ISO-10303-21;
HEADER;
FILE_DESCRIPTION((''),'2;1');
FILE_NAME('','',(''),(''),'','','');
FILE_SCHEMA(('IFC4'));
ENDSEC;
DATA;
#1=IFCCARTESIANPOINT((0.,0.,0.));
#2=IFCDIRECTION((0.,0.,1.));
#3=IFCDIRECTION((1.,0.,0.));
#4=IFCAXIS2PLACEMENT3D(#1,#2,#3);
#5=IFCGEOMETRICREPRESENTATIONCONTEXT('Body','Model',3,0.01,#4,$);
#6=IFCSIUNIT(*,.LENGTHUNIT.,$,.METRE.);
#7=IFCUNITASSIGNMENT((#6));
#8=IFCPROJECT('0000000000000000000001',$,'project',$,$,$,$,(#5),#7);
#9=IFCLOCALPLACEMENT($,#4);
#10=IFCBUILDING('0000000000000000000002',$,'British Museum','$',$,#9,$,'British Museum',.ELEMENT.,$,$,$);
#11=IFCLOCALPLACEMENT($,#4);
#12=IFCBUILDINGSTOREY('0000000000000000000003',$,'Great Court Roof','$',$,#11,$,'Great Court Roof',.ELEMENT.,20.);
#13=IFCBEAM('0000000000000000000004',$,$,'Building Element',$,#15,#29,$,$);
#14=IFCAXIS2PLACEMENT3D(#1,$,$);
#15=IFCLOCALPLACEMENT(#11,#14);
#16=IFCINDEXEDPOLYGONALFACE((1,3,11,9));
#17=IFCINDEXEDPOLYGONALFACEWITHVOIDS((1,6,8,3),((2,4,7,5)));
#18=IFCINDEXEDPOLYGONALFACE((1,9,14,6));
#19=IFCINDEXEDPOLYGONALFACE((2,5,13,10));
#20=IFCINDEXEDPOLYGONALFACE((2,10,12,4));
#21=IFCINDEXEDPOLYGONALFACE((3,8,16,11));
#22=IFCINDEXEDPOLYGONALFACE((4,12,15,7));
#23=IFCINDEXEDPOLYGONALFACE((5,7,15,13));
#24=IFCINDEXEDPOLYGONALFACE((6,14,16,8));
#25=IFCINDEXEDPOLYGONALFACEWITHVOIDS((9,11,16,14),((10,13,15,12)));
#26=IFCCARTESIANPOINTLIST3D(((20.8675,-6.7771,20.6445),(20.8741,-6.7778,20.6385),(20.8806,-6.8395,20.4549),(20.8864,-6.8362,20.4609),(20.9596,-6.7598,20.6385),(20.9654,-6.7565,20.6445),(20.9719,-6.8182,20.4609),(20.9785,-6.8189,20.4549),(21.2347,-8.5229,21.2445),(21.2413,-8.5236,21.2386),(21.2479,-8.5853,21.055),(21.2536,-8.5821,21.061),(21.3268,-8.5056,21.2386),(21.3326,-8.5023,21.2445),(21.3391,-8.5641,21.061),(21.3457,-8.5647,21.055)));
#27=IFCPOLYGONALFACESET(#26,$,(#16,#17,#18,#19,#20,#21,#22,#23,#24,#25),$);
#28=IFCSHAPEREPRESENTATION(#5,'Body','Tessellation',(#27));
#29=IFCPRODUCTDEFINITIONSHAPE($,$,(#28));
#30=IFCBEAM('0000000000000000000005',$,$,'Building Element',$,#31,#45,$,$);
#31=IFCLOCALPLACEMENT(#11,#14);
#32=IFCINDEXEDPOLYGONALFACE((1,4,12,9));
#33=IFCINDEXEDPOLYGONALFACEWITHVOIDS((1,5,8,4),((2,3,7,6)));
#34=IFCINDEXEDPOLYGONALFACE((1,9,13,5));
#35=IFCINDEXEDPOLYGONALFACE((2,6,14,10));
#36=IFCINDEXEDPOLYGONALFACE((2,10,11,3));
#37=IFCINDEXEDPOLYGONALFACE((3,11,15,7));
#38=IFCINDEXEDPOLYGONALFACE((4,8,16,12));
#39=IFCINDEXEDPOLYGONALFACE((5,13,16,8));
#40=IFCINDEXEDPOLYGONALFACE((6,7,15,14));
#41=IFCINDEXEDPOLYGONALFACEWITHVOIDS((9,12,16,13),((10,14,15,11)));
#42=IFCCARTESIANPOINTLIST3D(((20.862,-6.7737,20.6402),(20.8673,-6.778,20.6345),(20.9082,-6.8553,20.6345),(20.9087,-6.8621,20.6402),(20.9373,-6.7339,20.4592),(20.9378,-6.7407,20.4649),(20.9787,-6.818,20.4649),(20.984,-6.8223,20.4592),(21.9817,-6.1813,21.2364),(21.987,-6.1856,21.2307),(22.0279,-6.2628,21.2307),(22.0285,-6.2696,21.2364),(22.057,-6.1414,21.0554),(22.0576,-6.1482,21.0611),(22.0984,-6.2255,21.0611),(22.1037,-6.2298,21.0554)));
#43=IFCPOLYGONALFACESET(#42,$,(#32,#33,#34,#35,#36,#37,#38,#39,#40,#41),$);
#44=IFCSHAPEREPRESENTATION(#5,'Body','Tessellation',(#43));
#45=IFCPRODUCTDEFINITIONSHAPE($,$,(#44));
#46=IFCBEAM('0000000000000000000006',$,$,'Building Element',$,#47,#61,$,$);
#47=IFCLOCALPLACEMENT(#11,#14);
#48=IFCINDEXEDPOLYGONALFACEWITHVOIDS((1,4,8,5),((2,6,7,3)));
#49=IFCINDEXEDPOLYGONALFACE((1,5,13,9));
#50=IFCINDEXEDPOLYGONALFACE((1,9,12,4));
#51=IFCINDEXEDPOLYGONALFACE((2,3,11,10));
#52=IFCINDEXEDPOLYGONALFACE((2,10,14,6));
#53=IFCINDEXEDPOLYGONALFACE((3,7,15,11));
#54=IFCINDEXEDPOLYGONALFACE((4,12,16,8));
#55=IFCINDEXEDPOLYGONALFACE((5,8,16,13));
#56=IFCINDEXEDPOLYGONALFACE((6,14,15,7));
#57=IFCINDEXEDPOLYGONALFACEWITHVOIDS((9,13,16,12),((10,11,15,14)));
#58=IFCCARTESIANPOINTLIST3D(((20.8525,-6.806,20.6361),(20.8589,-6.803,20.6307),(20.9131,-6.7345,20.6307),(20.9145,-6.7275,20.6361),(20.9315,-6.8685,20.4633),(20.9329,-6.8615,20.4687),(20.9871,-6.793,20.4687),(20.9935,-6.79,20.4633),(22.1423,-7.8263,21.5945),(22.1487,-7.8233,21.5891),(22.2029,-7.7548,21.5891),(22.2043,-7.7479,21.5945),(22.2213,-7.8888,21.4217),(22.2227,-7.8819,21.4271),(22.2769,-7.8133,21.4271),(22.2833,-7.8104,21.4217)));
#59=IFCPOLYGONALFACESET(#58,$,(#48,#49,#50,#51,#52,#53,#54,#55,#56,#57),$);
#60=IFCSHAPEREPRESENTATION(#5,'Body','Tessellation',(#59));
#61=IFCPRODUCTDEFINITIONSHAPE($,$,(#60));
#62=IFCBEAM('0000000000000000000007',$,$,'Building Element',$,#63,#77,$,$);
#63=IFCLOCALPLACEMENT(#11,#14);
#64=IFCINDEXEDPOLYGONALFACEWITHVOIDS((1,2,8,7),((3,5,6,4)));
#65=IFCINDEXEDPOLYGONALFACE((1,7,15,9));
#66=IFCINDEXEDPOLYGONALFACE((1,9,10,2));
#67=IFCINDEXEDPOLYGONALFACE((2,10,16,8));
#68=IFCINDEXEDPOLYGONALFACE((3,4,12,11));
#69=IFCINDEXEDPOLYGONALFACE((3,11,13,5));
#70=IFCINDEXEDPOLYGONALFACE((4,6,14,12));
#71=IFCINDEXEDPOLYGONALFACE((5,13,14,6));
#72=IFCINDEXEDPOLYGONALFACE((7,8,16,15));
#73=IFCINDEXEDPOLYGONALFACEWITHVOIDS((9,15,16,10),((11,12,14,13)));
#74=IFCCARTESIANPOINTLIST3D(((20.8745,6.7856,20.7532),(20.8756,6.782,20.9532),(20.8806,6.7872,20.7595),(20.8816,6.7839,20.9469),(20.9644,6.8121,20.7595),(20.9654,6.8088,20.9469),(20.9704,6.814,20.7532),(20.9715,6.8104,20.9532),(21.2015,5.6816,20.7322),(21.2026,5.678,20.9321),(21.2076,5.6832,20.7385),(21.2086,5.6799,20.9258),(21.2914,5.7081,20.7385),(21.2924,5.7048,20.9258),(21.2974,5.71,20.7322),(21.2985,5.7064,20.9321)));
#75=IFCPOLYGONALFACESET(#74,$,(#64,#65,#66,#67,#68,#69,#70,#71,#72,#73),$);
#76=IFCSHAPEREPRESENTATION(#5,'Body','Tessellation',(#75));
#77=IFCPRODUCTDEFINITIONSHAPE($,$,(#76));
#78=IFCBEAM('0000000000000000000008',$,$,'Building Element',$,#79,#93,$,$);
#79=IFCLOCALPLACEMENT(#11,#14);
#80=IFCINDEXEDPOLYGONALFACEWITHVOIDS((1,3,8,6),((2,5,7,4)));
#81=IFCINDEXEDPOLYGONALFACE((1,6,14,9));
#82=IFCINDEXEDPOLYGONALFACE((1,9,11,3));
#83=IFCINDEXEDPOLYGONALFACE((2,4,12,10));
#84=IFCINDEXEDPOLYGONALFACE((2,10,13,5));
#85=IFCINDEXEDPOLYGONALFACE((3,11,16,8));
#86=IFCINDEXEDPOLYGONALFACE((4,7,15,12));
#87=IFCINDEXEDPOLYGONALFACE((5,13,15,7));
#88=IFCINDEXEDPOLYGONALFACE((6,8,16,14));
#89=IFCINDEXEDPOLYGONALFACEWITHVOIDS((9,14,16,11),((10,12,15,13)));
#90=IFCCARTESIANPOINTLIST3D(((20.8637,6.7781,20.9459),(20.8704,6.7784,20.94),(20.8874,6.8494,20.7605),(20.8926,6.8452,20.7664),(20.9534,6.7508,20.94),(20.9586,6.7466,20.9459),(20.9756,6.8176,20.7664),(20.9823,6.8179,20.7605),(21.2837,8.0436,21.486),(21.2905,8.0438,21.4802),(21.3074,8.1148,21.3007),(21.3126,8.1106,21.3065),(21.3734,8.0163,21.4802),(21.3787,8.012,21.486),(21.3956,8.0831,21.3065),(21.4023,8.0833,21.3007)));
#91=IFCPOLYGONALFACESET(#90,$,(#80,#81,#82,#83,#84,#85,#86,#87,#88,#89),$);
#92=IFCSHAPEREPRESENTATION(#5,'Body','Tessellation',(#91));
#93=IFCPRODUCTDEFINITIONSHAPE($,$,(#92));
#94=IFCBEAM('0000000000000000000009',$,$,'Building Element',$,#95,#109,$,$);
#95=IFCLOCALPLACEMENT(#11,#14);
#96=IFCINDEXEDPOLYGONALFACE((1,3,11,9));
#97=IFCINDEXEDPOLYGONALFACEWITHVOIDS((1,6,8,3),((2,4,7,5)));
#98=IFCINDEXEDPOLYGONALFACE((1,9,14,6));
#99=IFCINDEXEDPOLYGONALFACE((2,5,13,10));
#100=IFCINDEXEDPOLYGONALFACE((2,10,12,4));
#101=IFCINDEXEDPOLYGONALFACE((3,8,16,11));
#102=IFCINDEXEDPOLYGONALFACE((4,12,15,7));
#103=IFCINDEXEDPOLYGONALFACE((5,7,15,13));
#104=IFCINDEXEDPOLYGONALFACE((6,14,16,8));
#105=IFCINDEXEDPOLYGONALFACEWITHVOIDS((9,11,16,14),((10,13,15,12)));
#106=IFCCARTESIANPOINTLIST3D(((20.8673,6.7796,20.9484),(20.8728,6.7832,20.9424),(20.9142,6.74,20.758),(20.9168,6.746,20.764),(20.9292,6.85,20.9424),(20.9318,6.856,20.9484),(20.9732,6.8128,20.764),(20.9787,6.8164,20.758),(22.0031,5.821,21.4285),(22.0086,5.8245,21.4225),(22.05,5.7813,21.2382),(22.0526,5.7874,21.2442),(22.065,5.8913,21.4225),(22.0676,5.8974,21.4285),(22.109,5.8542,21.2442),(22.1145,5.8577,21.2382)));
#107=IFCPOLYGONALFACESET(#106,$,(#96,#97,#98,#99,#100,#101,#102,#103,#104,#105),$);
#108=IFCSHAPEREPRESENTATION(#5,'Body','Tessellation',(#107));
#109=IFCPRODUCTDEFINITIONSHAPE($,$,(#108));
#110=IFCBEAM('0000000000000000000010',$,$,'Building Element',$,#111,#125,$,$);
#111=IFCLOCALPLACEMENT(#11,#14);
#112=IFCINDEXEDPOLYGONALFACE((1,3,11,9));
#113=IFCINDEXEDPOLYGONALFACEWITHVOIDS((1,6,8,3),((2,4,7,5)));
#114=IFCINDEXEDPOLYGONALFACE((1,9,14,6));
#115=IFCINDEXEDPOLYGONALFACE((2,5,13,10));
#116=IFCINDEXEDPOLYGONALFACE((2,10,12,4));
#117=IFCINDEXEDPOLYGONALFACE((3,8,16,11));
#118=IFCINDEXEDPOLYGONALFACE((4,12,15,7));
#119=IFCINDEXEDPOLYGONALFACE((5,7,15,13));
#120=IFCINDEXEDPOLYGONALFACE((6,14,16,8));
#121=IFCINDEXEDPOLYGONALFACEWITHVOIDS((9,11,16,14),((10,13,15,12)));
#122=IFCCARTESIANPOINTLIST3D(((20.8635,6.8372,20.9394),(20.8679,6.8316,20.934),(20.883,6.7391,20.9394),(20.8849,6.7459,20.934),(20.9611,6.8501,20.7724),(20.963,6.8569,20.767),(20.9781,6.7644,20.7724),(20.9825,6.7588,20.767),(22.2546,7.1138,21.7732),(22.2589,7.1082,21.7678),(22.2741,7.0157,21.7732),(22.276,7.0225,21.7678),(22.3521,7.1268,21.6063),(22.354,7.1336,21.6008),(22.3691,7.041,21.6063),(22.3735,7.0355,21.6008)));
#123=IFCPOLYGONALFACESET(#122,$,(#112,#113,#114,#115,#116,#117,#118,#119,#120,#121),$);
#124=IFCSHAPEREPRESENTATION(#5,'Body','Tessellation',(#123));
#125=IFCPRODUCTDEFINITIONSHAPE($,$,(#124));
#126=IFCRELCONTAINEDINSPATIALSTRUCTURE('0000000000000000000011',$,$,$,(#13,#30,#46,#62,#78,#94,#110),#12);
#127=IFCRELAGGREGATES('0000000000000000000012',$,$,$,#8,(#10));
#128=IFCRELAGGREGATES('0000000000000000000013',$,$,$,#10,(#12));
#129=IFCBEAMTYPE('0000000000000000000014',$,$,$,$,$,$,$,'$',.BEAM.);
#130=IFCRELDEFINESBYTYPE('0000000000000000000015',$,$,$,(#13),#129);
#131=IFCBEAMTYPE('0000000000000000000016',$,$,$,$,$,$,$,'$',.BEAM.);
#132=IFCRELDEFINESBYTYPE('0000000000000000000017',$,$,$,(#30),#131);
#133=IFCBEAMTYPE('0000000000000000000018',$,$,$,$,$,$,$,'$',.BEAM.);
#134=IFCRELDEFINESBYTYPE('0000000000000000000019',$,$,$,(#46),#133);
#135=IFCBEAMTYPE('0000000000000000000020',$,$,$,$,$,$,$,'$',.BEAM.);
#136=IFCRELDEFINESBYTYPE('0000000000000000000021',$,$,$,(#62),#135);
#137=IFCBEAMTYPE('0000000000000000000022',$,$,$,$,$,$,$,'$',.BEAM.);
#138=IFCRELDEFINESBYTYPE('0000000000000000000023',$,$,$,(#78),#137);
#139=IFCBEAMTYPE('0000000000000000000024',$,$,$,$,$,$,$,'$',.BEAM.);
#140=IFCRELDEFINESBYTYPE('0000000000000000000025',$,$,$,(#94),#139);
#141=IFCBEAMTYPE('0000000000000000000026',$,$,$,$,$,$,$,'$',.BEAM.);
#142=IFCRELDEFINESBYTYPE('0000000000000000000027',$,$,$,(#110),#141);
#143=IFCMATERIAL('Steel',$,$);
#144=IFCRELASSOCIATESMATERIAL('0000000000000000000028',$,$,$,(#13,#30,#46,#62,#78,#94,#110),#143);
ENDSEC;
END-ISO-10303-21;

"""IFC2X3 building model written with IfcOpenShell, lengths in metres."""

from ifc_helpers import new_model, si_unit, frame, origin_with_axes, origin_2d, place, context, project, spatial, hollow_rectangle, extrude, material, type_object, element, save


model = new_model("IFC2X3")

# Units and contexts
model_context = context("Model", 3, precision=0.01, world=origin_with_axes(), identifier="Body")
ifc_project = project(units=[si_unit("LENGTHUNIT", "METRE")], contexts=[model_context])

# Building, storey
building_placement = place(None, origin_with_axes())
building = spatial("IfcBuilding", under=ifc_project, at=building_placement, Name="British Museum", Description="$", LongName="British Museum", CompositionType="ELEMENT")
storey_placement = place(None, origin_with_axes())
storey = spatial("IfcBuildingStorey", under=building, at=storey_placement, Name="Great Court Roof", Description="$", LongName="Great Court Roof", CompositionType="ELEMENT", Elevation=20.0)

# Beams
ifc_material = material(Name="Steel")
beam_type_1 = type_object("IfcBeamType", ElementType="$", PredefinedType="BEAM")
beam_1_placement = place(None, origin_with_axes())
element("IfcBeam", 1, at=beam_1_placement, inside=storey, type_object=beam_type_1, material=ifc_material, Description="Building Element", context=model_context, shape_type="SweptSolid", body=[
    extrude(hollow_rectangle(XDim=0.1, YDim=0.2, WallThickness=0.0063, InnerFilletRadius=-0.0063, OuterFilletRadius=0.0, at=origin_2d()), frame((20.923, -6.798, 20.5497), z_axis=(0.195098, -0.927526, 0.318799), x_axis=(0.978586, 0.205838, 0.0)), (0.0, 0.0, 1.0), 1.8823),
])
beam_type_2 = type_object("IfcBeamType", ElementType="$", PredefinedType="BEAM")
beam_2_placement = place(None, origin_with_axes())
element("IfcBeam", 2, at=beam_2_placement, inside=storey, type_object=beam_type_2, material=ifc_material, Description="Building Element", context=model_context, shape_type="SweptSolid", body=[
    extrude(hollow_rectangle(XDim=0.1, YDim=0.2, WallThickness=0.0063, InnerFilletRadius=-0.0063, OuterFilletRadius=0.0, at=origin_2d()), frame((20.923, -6.798, 20.5497), z_axis=(0.799754, 0.423164, 0.425823), x_axis=(-0.467685, 0.883895, 0.0)), (0.0, 0.0, 1.0), 1.4001),
])
beam_type_3 = type_object("IfcBeamType", ElementType="$", PredefinedType="BEAM")
beam_3_placement = place(None, origin_with_axes())
element("IfcBeam", 3, at=beam_3_placement, inside=storey, type_object=beam_type_3, material=ifc_material, Description="Building Element", context=model_context, shape_type="SweptSolid", body=[
    extrude(hollow_rectangle(XDim=0.1, YDim=0.2, WallThickness=0.0063, InnerFilletRadius=-0.0063, OuterFilletRadius=0.0, at=origin_2d()), frame((20.923, -6.798, 20.5497), z_axis=(0.677604, -0.536043, 0.503499), x_axis=(0.620423, 0.784268, 0.0)), (0.0, 0.0, 1.0), 1.9035),
])
beam_type_4 = type_object("IfcBeamType", ElementType="$", PredefinedType="BEAM")
beam_4_placement = place(None, origin_with_axes())
element("IfcBeam", 4, at=beam_4_placement, inside=storey, type_object=beam_type_4, material=ifc_material, Description="Building Element", context=model_context, shape_type="SweptSolid", body=[
    extrude(hollow_rectangle(XDim=0.1, YDim=0.2, WallThickness=0.0063, InnerFilletRadius=-0.0063, OuterFilletRadius=0.0, at=origin_2d()), frame((20.923, 6.798, 20.8532), z_axis=(0.283952, -0.958664, -0.018263), x_axis=(0.958824, 0.284, 0.0)), (0.0, 0.0, 1.0), 1.1516),
])
beam_type_5 = type_object("IfcBeamType", ElementType="$", PredefinedType="BEAM")
beam_5_placement = place(None, origin_with_axes())
element("IfcBeam", 5, at=beam_5_placement, inside=storey, type_object=beam_type_5, material=ifc_material, Description="Building Element", context=model_context, shape_type="SweptSolid", body=[
    extrude(hollow_rectangle(XDim=0.1, YDim=0.2, WallThickness=0.0063, InnerFilletRadius=-0.0063, OuterFilletRadius=0.0, at=origin_2d()), frame((20.923, 6.798, 20.8532), z_axis=(0.291971, 0.879638, 0.375486), x_axis=(-0.949085, 0.315021, 0.0)), (0.0, 0.0, 1.0), 1.4386),
])
beam_type_6 = type_object("IfcBeamType", ElementType="$", PredefinedType="BEAM")
beam_6_placement = place(None, origin_with_axes())
element("IfcBeam", 6, at=beam_6_placement, inside=storey, type_object=beam_type_6, material=ifc_material, Description="Building Element", context=model_context, shape_type="SweptSolid", body=[
    extrude(hollow_rectangle(XDim=0.1, YDim=0.2, WallThickness=0.0063, InnerFilletRadius=-0.0063, OuterFilletRadius=0.0, at=origin_2d()), frame((20.923, 6.798, 20.8532), z_axis=(0.72718, -0.613761, 0.307419), x_axis=(0.644995, 0.764187, 0.0)), (0.0, 0.0, 1.0), 1.5619),
])
beam_type_7 = type_object("IfcBeamType", ElementType="$", PredefinedType="BEAM")
beam_7_placement = place(None, origin_with_axes())
element("IfcBeam", 7, at=beam_7_placement, inside=storey, type_object=beam_type_7, material=ifc_material, Description="Building Element", context=model_context, shape_type="SweptSolid", body=[
    extrude(hollow_rectangle(XDim=0.1, YDim=0.2, WallThickness=0.0063, InnerFilletRadius=-0.0063, OuterFilletRadius=0.0, at=origin_2d()), frame((20.923, 6.798, 20.8532), z_axis=(0.845491, 0.16815, 0.506824), x_axis=(-0.195058, 0.980792, 0.0)), (0.0, 0.0, 1.0), 1.6452),
])

save(model, "model.ifc")
